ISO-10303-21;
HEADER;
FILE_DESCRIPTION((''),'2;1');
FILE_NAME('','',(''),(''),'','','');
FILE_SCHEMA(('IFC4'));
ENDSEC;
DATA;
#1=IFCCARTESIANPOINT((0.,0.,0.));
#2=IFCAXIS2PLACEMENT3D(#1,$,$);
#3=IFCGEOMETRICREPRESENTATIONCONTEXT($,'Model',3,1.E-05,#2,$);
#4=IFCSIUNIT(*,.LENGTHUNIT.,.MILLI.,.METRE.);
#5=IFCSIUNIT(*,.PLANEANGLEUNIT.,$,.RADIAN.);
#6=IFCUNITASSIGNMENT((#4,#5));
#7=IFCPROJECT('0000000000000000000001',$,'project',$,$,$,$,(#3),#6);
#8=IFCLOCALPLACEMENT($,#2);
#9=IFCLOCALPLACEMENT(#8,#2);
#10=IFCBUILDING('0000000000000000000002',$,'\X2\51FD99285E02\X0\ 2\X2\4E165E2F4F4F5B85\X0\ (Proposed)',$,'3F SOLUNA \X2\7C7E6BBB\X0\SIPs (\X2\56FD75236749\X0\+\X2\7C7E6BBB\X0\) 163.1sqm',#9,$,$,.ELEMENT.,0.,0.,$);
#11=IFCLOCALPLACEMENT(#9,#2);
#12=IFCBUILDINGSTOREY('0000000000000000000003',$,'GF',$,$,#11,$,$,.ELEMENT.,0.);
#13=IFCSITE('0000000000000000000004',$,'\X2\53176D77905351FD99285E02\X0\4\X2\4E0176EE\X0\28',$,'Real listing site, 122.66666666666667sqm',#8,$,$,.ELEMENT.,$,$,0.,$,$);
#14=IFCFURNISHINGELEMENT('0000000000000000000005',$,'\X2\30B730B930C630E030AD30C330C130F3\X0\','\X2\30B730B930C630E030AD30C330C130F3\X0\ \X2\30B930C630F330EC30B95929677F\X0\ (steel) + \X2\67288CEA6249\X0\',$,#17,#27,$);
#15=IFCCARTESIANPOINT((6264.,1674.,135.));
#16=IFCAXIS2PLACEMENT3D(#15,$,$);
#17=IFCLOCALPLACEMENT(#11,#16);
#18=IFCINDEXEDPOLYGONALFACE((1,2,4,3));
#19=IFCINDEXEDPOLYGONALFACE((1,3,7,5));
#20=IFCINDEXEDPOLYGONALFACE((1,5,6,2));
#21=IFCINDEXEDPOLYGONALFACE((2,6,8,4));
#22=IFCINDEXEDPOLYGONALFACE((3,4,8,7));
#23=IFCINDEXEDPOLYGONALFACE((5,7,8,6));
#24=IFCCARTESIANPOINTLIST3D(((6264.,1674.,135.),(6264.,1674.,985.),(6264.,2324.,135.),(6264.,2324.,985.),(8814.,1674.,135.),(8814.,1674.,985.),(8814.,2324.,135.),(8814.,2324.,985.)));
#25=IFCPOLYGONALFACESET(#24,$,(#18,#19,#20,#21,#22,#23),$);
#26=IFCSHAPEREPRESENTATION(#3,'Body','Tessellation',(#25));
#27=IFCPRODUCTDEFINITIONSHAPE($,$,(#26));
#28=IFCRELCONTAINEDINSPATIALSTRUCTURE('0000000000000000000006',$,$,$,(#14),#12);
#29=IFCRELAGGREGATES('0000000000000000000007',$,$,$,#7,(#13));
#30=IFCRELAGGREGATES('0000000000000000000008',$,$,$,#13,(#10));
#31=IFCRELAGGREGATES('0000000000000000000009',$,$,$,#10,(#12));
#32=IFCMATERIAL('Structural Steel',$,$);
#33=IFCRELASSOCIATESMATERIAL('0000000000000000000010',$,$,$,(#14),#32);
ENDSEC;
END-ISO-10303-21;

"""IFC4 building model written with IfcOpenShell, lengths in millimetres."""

from ifc_helpers import new_model, si_unit, frame, frame_2d, origin, place, context, project, spatial, rectangle, extrude, material, element, save


model = new_model("IFC4")

# Units and contexts
model_context = context("Model", 3, precision=1e-05, world=origin())
ifc_project = project(units=[si_unit("LENGTHUNIT", "METRE", prefix="MILLI"), si_unit("PLANEANGLEUNIT", "RADIAN")], contexts=[model_context])

# Site, building, storey
site_placement = place(None, origin())
site = spatial("IfcSite", under=ifc_project, at=site_placement, Name="北海道函館市4丁目28", ObjectType="Real listing site, 122.66666666666667sqm", CompositionType="ELEMENT", RefElevation=0.0)
building_placement = place(site_placement, origin())
building = spatial("IfcBuilding", under=site, at=building_placement, Name="函館市 2世帯住宅 (Proposed)", ObjectType="3F SOLUNA 籾殻SIPs (国産杉+籾殻) 163.1sqm", CompositionType="ELEMENT", ElevationOfRefHeight=0.0, ElevationOfTerrain=0.0)
storey_placement = place(building_placement, origin())
storey = spatial("IfcBuildingStorey", under=building, at=storey_placement, Name="GF", CompositionType="ELEMENT", Elevation=0.0)

# Furnishing element
ifc_material_1 = material(Name="Structural Steel")
furnishing_1_placement = place(storey_placement, frame((6264.0, 1674.0, 135.0)))
element("IfcFurnishingElement", 1, at=furnishing_1_placement, inside=storey, material=ifc_material_1, Name="システムキッチン", Description="システムキッチン ステンレス天板 (steel) + 木質扉", context=model_context, shape_type="SweptSolid", body=[
    extrude(rectangle(XDim=2550.0, YDim=650.0, at=frame_2d((1275.0, 325.0))), frame((6264.0, 1674.0, 135.0)), (0.0, 0.0, 1.0), 850.0),
])

save(model, "model.ifc")
